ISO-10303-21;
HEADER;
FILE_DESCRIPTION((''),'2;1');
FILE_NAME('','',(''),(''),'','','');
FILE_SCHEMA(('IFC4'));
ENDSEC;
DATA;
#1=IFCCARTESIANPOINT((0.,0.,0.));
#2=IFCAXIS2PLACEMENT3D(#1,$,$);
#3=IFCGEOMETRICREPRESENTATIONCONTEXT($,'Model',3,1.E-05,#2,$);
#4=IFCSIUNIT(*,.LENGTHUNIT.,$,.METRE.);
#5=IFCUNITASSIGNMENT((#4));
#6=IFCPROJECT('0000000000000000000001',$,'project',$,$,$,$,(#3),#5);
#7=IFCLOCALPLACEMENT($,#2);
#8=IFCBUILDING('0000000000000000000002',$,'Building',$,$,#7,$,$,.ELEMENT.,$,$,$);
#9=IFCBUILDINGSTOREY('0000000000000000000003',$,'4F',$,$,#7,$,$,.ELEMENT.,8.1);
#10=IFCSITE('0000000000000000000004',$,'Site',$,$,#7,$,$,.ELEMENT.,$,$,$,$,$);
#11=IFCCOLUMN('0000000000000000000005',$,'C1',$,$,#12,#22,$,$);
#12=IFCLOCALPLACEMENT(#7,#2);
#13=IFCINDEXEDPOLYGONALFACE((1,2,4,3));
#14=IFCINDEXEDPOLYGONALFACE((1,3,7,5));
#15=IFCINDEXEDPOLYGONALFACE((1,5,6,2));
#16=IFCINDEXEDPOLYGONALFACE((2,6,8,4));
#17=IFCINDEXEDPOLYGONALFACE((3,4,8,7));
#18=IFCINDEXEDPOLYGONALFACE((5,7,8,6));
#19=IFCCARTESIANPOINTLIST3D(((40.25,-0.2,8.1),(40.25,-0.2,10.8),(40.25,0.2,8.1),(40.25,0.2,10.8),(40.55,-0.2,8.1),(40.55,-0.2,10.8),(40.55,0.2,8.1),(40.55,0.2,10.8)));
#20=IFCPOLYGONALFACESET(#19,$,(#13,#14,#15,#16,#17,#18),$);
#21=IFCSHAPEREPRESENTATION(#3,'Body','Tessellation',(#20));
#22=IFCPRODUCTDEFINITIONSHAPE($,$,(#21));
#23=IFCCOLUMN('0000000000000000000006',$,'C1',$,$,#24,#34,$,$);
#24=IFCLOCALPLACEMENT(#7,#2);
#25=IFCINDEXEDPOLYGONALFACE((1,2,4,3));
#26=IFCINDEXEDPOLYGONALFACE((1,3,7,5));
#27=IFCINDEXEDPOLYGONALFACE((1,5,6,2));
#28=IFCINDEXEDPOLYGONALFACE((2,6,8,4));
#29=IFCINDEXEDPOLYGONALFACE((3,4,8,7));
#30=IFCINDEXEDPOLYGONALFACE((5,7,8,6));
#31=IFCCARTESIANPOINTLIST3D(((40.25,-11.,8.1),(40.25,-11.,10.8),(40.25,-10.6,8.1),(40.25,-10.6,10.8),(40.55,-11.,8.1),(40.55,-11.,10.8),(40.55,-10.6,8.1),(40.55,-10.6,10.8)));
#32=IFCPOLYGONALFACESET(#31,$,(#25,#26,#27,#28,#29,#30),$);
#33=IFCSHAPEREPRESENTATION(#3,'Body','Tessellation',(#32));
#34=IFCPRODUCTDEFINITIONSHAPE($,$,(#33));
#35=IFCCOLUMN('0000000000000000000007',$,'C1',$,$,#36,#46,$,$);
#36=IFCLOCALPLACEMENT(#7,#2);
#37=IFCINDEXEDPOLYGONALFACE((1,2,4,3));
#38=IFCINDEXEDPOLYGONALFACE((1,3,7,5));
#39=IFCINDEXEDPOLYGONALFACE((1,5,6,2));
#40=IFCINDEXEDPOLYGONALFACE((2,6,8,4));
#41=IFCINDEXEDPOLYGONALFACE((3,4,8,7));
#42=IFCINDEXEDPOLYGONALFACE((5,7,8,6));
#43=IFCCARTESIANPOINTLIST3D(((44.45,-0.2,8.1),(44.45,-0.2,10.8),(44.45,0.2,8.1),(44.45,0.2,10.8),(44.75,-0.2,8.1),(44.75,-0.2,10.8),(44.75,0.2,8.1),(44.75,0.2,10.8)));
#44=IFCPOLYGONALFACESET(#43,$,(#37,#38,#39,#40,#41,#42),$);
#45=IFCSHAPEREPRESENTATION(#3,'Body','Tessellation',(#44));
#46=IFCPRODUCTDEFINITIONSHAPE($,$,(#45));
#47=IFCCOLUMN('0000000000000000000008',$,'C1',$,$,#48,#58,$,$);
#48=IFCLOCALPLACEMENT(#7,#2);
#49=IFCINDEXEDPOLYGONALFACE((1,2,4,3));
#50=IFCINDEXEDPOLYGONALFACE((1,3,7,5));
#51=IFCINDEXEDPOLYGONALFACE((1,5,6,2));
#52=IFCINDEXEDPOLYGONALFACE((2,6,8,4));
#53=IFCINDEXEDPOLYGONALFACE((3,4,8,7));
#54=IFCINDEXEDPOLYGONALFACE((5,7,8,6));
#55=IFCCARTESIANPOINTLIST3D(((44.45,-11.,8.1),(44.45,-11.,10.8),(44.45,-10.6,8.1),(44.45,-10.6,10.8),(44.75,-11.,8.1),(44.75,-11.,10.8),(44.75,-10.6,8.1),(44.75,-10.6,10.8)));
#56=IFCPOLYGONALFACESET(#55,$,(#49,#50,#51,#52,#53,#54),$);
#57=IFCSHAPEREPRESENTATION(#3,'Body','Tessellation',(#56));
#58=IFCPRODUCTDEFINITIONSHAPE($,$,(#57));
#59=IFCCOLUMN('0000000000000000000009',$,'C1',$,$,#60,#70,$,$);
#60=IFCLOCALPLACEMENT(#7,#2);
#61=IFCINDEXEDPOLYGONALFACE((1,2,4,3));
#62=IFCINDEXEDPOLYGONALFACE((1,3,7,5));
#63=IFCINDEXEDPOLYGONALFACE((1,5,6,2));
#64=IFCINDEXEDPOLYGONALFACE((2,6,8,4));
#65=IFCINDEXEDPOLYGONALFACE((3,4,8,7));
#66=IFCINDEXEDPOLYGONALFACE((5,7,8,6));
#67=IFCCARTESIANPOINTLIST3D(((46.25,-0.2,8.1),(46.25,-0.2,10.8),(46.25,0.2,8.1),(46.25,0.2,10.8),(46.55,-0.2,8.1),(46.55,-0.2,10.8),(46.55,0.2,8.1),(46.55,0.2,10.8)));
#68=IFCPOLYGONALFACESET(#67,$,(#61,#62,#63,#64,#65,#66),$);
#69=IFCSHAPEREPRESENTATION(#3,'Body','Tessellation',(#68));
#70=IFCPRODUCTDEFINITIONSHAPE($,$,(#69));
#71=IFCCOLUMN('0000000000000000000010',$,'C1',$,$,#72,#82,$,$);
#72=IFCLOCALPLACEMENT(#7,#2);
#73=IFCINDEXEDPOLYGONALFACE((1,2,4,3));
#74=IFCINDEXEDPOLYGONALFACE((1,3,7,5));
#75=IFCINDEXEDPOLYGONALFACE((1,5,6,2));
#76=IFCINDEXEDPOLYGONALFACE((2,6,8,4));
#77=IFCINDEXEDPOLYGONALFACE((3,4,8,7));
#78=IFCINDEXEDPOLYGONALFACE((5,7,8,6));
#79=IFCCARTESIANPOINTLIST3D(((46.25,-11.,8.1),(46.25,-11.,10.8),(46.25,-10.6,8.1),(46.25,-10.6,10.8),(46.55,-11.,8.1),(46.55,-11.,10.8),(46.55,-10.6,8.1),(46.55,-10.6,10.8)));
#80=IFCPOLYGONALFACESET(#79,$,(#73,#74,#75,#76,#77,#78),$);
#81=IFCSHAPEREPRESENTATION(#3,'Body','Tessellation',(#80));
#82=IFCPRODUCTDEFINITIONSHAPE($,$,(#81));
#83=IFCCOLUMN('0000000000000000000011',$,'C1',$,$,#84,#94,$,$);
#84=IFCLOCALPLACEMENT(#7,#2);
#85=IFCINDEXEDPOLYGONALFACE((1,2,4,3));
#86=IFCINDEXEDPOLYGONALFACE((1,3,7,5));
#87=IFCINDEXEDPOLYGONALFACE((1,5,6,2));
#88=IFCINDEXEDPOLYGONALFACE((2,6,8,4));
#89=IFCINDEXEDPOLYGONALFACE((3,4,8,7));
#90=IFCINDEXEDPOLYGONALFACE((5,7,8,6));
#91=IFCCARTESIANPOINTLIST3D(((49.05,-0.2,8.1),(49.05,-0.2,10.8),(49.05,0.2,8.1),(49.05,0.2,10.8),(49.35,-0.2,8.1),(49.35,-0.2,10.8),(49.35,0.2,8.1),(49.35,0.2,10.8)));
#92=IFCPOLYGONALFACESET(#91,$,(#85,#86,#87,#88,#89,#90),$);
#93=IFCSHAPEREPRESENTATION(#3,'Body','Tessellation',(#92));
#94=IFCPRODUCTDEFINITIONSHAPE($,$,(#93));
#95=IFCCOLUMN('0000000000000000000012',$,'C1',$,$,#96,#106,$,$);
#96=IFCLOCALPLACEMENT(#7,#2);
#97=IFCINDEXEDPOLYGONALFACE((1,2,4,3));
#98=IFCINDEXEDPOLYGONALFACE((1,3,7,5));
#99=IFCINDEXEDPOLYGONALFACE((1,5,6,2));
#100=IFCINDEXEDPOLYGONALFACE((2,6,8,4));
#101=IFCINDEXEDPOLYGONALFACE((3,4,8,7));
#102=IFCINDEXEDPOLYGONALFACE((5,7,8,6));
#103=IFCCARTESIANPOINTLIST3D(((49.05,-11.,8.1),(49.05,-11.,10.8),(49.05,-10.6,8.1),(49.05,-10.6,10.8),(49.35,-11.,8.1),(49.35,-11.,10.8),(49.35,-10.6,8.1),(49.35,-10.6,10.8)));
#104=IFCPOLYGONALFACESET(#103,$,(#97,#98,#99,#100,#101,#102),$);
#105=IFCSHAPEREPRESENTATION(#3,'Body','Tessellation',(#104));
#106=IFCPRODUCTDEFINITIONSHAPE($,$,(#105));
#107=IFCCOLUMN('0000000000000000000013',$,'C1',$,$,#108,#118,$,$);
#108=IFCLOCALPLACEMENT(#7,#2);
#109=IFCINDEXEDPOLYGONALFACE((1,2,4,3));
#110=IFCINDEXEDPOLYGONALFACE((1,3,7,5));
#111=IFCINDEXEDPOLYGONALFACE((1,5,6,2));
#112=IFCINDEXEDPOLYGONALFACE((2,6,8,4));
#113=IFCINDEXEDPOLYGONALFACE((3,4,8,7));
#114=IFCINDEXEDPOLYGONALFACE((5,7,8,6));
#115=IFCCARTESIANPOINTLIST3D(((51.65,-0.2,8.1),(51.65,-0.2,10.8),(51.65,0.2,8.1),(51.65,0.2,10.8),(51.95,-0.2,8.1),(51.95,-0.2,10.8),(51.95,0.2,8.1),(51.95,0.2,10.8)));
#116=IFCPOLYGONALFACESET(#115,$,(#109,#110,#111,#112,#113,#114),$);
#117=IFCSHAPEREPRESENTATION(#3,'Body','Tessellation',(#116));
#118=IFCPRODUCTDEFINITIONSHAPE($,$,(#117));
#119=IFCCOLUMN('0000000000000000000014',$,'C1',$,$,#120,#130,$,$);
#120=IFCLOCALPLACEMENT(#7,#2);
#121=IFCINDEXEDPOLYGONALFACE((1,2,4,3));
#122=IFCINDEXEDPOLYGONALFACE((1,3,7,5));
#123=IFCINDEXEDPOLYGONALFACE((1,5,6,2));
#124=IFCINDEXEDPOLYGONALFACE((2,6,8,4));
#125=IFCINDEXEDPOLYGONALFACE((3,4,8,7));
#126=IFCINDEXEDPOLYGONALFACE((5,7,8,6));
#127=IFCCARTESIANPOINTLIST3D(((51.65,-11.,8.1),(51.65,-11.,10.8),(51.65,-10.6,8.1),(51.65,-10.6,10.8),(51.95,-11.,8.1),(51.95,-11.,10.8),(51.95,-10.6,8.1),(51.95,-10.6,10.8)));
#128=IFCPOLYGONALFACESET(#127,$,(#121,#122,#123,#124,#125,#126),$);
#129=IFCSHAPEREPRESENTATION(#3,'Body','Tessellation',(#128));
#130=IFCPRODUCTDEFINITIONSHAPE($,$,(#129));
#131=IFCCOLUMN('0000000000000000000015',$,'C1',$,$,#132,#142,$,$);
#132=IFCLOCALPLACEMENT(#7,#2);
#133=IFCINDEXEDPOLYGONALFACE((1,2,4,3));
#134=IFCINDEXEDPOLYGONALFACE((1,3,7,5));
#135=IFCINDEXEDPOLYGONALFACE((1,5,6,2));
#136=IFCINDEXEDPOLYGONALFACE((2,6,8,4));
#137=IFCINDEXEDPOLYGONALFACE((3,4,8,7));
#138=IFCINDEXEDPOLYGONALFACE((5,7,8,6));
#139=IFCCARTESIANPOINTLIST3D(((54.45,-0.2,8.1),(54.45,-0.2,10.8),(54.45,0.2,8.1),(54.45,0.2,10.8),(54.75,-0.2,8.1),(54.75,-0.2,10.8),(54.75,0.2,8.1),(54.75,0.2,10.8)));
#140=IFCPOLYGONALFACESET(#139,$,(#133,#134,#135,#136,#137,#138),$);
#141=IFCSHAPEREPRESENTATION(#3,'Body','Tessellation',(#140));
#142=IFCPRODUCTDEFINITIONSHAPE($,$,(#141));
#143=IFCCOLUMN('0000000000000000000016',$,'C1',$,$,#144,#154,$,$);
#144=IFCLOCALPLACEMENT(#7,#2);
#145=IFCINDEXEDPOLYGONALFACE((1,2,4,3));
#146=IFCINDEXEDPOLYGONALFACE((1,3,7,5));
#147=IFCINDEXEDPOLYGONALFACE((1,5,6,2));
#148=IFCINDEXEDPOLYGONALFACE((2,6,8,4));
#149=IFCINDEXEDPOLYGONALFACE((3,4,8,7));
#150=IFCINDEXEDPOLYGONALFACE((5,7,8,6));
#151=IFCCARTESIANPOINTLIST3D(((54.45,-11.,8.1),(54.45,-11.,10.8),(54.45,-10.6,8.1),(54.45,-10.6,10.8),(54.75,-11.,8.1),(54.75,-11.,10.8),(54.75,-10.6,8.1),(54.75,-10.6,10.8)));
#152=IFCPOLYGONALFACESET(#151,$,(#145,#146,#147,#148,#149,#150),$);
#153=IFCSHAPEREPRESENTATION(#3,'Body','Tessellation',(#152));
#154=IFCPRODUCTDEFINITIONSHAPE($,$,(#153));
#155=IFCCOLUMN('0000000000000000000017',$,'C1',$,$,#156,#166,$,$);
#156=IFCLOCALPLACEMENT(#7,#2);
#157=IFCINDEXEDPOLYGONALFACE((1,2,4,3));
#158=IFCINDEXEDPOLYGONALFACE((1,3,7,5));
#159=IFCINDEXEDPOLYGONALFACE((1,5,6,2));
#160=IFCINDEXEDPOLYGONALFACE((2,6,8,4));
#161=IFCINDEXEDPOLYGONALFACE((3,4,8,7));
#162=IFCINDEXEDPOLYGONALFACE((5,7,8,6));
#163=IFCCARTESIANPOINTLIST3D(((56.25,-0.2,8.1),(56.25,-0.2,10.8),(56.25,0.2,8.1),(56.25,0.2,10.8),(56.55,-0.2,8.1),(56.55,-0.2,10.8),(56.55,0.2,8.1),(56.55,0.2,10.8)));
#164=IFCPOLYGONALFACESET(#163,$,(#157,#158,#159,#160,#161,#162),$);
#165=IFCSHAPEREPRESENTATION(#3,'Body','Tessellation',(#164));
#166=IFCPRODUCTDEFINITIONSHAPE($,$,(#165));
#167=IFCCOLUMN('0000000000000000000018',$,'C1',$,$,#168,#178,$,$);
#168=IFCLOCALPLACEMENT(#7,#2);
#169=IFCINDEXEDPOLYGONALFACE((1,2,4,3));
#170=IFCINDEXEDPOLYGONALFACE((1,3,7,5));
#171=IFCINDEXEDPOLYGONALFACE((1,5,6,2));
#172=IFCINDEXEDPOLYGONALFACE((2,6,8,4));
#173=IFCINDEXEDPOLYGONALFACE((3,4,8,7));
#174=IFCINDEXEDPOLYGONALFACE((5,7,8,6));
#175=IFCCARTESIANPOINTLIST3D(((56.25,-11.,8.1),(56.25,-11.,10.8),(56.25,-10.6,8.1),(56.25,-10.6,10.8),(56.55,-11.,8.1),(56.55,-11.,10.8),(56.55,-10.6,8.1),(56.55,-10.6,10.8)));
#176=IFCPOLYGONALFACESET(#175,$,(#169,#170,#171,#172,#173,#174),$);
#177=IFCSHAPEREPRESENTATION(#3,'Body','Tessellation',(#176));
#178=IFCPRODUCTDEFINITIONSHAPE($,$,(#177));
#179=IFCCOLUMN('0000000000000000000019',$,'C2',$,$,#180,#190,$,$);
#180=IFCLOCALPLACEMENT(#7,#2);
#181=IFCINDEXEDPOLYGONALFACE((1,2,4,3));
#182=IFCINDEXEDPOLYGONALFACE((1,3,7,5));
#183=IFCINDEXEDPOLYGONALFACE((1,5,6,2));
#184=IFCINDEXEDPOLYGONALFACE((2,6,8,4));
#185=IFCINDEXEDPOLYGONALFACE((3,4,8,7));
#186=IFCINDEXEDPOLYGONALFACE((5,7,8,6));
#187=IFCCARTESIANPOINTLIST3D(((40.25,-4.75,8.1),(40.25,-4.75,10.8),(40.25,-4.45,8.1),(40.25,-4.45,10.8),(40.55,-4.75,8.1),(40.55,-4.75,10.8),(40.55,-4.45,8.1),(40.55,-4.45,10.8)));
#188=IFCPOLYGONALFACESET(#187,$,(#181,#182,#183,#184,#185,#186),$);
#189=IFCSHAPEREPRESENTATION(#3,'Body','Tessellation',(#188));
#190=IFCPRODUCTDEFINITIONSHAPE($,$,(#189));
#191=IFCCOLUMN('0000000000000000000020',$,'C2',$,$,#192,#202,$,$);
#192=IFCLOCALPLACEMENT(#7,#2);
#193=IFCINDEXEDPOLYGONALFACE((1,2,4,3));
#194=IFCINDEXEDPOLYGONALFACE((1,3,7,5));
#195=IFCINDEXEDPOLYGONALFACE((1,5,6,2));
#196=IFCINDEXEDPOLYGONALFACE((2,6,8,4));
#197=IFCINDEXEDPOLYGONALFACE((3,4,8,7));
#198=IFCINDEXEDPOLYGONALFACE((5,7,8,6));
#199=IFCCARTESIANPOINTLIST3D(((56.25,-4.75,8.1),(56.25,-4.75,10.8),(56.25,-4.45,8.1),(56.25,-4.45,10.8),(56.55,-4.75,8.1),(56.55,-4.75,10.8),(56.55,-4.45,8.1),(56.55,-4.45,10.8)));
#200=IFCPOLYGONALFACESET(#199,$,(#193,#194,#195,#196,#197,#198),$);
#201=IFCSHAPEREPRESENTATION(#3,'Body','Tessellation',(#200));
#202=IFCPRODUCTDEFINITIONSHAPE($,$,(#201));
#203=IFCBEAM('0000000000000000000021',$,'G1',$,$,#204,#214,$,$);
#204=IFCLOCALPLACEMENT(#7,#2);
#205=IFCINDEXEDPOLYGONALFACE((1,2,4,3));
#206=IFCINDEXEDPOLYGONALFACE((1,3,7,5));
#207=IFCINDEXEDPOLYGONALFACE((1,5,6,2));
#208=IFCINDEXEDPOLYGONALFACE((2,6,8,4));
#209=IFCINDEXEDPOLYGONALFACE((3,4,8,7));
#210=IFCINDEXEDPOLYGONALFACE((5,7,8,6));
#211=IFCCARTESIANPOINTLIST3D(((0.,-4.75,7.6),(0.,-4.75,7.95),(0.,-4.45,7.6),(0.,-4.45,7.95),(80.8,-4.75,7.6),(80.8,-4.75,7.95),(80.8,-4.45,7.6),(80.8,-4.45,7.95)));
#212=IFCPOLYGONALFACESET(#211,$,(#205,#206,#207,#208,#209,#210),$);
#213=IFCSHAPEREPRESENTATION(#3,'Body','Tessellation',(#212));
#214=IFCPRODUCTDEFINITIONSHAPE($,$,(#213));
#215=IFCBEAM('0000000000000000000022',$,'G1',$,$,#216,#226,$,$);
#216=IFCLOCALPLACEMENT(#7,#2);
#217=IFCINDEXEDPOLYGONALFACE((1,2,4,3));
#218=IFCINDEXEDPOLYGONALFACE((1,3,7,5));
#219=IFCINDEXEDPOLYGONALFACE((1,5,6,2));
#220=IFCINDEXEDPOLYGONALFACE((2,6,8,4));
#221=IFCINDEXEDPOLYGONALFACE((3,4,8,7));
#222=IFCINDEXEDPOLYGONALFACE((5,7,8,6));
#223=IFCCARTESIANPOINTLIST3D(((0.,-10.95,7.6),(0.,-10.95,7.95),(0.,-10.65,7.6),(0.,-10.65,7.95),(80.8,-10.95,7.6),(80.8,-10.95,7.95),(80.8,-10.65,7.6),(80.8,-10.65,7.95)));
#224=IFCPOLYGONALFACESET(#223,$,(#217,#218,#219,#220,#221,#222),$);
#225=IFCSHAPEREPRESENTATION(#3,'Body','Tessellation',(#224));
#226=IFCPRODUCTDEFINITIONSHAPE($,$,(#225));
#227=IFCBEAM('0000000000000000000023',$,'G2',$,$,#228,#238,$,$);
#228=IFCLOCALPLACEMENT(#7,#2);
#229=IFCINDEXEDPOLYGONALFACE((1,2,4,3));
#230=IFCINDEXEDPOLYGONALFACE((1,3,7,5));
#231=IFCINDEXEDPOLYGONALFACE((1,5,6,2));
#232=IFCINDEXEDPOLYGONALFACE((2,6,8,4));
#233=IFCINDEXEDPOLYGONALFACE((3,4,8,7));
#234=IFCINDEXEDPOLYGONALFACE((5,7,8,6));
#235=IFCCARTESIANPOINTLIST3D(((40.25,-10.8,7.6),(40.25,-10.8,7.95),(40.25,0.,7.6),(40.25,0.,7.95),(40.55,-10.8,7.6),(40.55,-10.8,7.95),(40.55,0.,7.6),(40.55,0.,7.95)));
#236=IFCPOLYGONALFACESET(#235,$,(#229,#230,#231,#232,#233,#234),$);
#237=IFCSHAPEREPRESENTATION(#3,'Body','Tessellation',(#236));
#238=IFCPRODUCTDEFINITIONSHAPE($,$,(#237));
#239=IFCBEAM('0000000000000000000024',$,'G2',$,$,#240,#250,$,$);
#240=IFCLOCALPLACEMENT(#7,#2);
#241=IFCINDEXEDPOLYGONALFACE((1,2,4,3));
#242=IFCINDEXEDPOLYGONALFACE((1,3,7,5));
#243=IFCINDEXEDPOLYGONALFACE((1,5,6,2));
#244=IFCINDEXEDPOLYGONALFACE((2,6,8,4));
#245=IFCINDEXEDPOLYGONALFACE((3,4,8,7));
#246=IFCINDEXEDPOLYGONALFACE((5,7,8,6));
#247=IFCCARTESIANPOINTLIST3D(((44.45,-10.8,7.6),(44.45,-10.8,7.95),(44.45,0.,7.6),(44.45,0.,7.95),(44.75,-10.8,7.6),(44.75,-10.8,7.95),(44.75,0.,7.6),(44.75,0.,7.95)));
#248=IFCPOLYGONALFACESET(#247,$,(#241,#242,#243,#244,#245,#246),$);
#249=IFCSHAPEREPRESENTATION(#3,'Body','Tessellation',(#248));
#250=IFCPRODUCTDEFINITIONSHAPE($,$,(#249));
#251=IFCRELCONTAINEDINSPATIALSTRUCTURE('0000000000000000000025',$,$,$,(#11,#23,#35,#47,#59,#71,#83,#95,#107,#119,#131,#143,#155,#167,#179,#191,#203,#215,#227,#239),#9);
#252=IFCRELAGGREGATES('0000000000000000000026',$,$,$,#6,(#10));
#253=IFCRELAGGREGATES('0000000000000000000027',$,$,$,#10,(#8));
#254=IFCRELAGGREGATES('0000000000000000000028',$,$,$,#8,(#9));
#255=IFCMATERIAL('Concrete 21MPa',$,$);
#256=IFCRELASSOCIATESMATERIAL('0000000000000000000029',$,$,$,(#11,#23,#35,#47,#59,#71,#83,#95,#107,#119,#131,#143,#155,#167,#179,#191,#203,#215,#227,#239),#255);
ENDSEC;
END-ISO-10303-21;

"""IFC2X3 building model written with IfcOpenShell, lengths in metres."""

from ifc_helpers import new_model, si_unit, frame, origin, origin_2d, place, context, project, spatial, rectangle, extrude, material, element, save


model = new_model("IFC2X3")

# Units and contexts
model_context = context("Model", 3, precision=1e-05, world=origin())
ifc_project = project(units=[si_unit("LENGTHUNIT", "METRE")], contexts=[model_context])

# Site, building, storey
placement = place(None, origin())
site = spatial("IfcSite", under=ifc_project, at=placement, Name="Site", CompositionType="ELEMENT")
building = spatial("IfcBuilding", under=site, at=placement, Name="Building", CompositionType="ELEMENT")
storey = spatial("IfcBuildingStorey", under=building, at=placement, Name="4F", CompositionType="ELEMENT", Elevation=8.1)

# Columns
ifc_material = material(Name="Concrete 21MPa")
for number, where, name in (
    (1, (40.4, 0.0, 8.1), "C1"),
    (2, (40.4, -10.8, 8.1), "C1"),
    (3, (44.6, 0.0, 8.1), "C1"),
    (4, (44.6, -10.8, 8.1), "C1"),
    (5, (46.4, 0.0, 8.1), "C1"),
    (6, (46.4, -10.8, 8.1), "C1"),
    (7, (49.2, 0.0, 8.1), "C1"),
    (8, (49.2, -10.8, 8.1), "C1"),
    (9, (51.8, 0.0, 8.1), "C1"),
    (10, (51.8, -10.8, 8.1), "C1"),
    (11, (54.6, 0.0, 8.1), "C1"),
    (12, (54.6, -10.8, 8.1), "C1"),
    (13, (56.4, 0.0, 8.1), "C1"),
    (14, (56.4, -10.8, 8.1), "C1"),
):
    element("IfcColumn", number, at=place(None, frame(where)), inside=storey, material=ifc_material, Name=name, context=model_context, shape_type="SweptSolid", body=[
        extrude(rectangle(XDim=0.3, YDim=0.4, at=origin_2d()), origin(), (0.0, 0.0, 1.0), 2.7),
    ])
for number, where, name in (
    (15, (40.4, -4.6, 8.1), "C2"),
    (16, (56.4, -4.6, 8.1), "C2"),
):
    element("IfcColumn", number, at=place(None, frame(where)), inside=storey, material=ifc_material, Name=name, context=model_context, shape_type="SweptSolid", body=[
        extrude(rectangle(XDim=0.3, YDim=0.3, at=origin_2d()), origin(), (0.0, 0.0, 1.0), 2.7),
    ])

# Beams
for number, where, name in (
    (17, (40.4, -4.6, 7.6), "G1"),
    (18, (40.4, -10.8, 7.6), "G1"),
):
    element("IfcBeam", number, at=place(None, frame(where)), inside=storey, material=ifc_material, Name=name, context=model_context, shape_type="SweptSolid", body=[
        extrude(rectangle(XDim=80.8, YDim=0.3, at=origin_2d()), origin(), (0.0, 0.0, 1.0), 0.35),
    ])
for number, where, name in (
    (19, (40.4, -5.4, 7.6), "G2"),
    (20, (44.6, -5.4, 7.6), "G2"),
):
    element("IfcBeam", number, at=place(None, frame(where)), inside=storey, material=ifc_material, Name=name, context=model_context, shape_type="SweptSolid", body=[
        extrude(rectangle(XDim=0.3, YDim=10.8, at=origin_2d()), origin(), (0.0, 0.0, 1.0), 0.35),
    ])

save(model, "model.ifc")
